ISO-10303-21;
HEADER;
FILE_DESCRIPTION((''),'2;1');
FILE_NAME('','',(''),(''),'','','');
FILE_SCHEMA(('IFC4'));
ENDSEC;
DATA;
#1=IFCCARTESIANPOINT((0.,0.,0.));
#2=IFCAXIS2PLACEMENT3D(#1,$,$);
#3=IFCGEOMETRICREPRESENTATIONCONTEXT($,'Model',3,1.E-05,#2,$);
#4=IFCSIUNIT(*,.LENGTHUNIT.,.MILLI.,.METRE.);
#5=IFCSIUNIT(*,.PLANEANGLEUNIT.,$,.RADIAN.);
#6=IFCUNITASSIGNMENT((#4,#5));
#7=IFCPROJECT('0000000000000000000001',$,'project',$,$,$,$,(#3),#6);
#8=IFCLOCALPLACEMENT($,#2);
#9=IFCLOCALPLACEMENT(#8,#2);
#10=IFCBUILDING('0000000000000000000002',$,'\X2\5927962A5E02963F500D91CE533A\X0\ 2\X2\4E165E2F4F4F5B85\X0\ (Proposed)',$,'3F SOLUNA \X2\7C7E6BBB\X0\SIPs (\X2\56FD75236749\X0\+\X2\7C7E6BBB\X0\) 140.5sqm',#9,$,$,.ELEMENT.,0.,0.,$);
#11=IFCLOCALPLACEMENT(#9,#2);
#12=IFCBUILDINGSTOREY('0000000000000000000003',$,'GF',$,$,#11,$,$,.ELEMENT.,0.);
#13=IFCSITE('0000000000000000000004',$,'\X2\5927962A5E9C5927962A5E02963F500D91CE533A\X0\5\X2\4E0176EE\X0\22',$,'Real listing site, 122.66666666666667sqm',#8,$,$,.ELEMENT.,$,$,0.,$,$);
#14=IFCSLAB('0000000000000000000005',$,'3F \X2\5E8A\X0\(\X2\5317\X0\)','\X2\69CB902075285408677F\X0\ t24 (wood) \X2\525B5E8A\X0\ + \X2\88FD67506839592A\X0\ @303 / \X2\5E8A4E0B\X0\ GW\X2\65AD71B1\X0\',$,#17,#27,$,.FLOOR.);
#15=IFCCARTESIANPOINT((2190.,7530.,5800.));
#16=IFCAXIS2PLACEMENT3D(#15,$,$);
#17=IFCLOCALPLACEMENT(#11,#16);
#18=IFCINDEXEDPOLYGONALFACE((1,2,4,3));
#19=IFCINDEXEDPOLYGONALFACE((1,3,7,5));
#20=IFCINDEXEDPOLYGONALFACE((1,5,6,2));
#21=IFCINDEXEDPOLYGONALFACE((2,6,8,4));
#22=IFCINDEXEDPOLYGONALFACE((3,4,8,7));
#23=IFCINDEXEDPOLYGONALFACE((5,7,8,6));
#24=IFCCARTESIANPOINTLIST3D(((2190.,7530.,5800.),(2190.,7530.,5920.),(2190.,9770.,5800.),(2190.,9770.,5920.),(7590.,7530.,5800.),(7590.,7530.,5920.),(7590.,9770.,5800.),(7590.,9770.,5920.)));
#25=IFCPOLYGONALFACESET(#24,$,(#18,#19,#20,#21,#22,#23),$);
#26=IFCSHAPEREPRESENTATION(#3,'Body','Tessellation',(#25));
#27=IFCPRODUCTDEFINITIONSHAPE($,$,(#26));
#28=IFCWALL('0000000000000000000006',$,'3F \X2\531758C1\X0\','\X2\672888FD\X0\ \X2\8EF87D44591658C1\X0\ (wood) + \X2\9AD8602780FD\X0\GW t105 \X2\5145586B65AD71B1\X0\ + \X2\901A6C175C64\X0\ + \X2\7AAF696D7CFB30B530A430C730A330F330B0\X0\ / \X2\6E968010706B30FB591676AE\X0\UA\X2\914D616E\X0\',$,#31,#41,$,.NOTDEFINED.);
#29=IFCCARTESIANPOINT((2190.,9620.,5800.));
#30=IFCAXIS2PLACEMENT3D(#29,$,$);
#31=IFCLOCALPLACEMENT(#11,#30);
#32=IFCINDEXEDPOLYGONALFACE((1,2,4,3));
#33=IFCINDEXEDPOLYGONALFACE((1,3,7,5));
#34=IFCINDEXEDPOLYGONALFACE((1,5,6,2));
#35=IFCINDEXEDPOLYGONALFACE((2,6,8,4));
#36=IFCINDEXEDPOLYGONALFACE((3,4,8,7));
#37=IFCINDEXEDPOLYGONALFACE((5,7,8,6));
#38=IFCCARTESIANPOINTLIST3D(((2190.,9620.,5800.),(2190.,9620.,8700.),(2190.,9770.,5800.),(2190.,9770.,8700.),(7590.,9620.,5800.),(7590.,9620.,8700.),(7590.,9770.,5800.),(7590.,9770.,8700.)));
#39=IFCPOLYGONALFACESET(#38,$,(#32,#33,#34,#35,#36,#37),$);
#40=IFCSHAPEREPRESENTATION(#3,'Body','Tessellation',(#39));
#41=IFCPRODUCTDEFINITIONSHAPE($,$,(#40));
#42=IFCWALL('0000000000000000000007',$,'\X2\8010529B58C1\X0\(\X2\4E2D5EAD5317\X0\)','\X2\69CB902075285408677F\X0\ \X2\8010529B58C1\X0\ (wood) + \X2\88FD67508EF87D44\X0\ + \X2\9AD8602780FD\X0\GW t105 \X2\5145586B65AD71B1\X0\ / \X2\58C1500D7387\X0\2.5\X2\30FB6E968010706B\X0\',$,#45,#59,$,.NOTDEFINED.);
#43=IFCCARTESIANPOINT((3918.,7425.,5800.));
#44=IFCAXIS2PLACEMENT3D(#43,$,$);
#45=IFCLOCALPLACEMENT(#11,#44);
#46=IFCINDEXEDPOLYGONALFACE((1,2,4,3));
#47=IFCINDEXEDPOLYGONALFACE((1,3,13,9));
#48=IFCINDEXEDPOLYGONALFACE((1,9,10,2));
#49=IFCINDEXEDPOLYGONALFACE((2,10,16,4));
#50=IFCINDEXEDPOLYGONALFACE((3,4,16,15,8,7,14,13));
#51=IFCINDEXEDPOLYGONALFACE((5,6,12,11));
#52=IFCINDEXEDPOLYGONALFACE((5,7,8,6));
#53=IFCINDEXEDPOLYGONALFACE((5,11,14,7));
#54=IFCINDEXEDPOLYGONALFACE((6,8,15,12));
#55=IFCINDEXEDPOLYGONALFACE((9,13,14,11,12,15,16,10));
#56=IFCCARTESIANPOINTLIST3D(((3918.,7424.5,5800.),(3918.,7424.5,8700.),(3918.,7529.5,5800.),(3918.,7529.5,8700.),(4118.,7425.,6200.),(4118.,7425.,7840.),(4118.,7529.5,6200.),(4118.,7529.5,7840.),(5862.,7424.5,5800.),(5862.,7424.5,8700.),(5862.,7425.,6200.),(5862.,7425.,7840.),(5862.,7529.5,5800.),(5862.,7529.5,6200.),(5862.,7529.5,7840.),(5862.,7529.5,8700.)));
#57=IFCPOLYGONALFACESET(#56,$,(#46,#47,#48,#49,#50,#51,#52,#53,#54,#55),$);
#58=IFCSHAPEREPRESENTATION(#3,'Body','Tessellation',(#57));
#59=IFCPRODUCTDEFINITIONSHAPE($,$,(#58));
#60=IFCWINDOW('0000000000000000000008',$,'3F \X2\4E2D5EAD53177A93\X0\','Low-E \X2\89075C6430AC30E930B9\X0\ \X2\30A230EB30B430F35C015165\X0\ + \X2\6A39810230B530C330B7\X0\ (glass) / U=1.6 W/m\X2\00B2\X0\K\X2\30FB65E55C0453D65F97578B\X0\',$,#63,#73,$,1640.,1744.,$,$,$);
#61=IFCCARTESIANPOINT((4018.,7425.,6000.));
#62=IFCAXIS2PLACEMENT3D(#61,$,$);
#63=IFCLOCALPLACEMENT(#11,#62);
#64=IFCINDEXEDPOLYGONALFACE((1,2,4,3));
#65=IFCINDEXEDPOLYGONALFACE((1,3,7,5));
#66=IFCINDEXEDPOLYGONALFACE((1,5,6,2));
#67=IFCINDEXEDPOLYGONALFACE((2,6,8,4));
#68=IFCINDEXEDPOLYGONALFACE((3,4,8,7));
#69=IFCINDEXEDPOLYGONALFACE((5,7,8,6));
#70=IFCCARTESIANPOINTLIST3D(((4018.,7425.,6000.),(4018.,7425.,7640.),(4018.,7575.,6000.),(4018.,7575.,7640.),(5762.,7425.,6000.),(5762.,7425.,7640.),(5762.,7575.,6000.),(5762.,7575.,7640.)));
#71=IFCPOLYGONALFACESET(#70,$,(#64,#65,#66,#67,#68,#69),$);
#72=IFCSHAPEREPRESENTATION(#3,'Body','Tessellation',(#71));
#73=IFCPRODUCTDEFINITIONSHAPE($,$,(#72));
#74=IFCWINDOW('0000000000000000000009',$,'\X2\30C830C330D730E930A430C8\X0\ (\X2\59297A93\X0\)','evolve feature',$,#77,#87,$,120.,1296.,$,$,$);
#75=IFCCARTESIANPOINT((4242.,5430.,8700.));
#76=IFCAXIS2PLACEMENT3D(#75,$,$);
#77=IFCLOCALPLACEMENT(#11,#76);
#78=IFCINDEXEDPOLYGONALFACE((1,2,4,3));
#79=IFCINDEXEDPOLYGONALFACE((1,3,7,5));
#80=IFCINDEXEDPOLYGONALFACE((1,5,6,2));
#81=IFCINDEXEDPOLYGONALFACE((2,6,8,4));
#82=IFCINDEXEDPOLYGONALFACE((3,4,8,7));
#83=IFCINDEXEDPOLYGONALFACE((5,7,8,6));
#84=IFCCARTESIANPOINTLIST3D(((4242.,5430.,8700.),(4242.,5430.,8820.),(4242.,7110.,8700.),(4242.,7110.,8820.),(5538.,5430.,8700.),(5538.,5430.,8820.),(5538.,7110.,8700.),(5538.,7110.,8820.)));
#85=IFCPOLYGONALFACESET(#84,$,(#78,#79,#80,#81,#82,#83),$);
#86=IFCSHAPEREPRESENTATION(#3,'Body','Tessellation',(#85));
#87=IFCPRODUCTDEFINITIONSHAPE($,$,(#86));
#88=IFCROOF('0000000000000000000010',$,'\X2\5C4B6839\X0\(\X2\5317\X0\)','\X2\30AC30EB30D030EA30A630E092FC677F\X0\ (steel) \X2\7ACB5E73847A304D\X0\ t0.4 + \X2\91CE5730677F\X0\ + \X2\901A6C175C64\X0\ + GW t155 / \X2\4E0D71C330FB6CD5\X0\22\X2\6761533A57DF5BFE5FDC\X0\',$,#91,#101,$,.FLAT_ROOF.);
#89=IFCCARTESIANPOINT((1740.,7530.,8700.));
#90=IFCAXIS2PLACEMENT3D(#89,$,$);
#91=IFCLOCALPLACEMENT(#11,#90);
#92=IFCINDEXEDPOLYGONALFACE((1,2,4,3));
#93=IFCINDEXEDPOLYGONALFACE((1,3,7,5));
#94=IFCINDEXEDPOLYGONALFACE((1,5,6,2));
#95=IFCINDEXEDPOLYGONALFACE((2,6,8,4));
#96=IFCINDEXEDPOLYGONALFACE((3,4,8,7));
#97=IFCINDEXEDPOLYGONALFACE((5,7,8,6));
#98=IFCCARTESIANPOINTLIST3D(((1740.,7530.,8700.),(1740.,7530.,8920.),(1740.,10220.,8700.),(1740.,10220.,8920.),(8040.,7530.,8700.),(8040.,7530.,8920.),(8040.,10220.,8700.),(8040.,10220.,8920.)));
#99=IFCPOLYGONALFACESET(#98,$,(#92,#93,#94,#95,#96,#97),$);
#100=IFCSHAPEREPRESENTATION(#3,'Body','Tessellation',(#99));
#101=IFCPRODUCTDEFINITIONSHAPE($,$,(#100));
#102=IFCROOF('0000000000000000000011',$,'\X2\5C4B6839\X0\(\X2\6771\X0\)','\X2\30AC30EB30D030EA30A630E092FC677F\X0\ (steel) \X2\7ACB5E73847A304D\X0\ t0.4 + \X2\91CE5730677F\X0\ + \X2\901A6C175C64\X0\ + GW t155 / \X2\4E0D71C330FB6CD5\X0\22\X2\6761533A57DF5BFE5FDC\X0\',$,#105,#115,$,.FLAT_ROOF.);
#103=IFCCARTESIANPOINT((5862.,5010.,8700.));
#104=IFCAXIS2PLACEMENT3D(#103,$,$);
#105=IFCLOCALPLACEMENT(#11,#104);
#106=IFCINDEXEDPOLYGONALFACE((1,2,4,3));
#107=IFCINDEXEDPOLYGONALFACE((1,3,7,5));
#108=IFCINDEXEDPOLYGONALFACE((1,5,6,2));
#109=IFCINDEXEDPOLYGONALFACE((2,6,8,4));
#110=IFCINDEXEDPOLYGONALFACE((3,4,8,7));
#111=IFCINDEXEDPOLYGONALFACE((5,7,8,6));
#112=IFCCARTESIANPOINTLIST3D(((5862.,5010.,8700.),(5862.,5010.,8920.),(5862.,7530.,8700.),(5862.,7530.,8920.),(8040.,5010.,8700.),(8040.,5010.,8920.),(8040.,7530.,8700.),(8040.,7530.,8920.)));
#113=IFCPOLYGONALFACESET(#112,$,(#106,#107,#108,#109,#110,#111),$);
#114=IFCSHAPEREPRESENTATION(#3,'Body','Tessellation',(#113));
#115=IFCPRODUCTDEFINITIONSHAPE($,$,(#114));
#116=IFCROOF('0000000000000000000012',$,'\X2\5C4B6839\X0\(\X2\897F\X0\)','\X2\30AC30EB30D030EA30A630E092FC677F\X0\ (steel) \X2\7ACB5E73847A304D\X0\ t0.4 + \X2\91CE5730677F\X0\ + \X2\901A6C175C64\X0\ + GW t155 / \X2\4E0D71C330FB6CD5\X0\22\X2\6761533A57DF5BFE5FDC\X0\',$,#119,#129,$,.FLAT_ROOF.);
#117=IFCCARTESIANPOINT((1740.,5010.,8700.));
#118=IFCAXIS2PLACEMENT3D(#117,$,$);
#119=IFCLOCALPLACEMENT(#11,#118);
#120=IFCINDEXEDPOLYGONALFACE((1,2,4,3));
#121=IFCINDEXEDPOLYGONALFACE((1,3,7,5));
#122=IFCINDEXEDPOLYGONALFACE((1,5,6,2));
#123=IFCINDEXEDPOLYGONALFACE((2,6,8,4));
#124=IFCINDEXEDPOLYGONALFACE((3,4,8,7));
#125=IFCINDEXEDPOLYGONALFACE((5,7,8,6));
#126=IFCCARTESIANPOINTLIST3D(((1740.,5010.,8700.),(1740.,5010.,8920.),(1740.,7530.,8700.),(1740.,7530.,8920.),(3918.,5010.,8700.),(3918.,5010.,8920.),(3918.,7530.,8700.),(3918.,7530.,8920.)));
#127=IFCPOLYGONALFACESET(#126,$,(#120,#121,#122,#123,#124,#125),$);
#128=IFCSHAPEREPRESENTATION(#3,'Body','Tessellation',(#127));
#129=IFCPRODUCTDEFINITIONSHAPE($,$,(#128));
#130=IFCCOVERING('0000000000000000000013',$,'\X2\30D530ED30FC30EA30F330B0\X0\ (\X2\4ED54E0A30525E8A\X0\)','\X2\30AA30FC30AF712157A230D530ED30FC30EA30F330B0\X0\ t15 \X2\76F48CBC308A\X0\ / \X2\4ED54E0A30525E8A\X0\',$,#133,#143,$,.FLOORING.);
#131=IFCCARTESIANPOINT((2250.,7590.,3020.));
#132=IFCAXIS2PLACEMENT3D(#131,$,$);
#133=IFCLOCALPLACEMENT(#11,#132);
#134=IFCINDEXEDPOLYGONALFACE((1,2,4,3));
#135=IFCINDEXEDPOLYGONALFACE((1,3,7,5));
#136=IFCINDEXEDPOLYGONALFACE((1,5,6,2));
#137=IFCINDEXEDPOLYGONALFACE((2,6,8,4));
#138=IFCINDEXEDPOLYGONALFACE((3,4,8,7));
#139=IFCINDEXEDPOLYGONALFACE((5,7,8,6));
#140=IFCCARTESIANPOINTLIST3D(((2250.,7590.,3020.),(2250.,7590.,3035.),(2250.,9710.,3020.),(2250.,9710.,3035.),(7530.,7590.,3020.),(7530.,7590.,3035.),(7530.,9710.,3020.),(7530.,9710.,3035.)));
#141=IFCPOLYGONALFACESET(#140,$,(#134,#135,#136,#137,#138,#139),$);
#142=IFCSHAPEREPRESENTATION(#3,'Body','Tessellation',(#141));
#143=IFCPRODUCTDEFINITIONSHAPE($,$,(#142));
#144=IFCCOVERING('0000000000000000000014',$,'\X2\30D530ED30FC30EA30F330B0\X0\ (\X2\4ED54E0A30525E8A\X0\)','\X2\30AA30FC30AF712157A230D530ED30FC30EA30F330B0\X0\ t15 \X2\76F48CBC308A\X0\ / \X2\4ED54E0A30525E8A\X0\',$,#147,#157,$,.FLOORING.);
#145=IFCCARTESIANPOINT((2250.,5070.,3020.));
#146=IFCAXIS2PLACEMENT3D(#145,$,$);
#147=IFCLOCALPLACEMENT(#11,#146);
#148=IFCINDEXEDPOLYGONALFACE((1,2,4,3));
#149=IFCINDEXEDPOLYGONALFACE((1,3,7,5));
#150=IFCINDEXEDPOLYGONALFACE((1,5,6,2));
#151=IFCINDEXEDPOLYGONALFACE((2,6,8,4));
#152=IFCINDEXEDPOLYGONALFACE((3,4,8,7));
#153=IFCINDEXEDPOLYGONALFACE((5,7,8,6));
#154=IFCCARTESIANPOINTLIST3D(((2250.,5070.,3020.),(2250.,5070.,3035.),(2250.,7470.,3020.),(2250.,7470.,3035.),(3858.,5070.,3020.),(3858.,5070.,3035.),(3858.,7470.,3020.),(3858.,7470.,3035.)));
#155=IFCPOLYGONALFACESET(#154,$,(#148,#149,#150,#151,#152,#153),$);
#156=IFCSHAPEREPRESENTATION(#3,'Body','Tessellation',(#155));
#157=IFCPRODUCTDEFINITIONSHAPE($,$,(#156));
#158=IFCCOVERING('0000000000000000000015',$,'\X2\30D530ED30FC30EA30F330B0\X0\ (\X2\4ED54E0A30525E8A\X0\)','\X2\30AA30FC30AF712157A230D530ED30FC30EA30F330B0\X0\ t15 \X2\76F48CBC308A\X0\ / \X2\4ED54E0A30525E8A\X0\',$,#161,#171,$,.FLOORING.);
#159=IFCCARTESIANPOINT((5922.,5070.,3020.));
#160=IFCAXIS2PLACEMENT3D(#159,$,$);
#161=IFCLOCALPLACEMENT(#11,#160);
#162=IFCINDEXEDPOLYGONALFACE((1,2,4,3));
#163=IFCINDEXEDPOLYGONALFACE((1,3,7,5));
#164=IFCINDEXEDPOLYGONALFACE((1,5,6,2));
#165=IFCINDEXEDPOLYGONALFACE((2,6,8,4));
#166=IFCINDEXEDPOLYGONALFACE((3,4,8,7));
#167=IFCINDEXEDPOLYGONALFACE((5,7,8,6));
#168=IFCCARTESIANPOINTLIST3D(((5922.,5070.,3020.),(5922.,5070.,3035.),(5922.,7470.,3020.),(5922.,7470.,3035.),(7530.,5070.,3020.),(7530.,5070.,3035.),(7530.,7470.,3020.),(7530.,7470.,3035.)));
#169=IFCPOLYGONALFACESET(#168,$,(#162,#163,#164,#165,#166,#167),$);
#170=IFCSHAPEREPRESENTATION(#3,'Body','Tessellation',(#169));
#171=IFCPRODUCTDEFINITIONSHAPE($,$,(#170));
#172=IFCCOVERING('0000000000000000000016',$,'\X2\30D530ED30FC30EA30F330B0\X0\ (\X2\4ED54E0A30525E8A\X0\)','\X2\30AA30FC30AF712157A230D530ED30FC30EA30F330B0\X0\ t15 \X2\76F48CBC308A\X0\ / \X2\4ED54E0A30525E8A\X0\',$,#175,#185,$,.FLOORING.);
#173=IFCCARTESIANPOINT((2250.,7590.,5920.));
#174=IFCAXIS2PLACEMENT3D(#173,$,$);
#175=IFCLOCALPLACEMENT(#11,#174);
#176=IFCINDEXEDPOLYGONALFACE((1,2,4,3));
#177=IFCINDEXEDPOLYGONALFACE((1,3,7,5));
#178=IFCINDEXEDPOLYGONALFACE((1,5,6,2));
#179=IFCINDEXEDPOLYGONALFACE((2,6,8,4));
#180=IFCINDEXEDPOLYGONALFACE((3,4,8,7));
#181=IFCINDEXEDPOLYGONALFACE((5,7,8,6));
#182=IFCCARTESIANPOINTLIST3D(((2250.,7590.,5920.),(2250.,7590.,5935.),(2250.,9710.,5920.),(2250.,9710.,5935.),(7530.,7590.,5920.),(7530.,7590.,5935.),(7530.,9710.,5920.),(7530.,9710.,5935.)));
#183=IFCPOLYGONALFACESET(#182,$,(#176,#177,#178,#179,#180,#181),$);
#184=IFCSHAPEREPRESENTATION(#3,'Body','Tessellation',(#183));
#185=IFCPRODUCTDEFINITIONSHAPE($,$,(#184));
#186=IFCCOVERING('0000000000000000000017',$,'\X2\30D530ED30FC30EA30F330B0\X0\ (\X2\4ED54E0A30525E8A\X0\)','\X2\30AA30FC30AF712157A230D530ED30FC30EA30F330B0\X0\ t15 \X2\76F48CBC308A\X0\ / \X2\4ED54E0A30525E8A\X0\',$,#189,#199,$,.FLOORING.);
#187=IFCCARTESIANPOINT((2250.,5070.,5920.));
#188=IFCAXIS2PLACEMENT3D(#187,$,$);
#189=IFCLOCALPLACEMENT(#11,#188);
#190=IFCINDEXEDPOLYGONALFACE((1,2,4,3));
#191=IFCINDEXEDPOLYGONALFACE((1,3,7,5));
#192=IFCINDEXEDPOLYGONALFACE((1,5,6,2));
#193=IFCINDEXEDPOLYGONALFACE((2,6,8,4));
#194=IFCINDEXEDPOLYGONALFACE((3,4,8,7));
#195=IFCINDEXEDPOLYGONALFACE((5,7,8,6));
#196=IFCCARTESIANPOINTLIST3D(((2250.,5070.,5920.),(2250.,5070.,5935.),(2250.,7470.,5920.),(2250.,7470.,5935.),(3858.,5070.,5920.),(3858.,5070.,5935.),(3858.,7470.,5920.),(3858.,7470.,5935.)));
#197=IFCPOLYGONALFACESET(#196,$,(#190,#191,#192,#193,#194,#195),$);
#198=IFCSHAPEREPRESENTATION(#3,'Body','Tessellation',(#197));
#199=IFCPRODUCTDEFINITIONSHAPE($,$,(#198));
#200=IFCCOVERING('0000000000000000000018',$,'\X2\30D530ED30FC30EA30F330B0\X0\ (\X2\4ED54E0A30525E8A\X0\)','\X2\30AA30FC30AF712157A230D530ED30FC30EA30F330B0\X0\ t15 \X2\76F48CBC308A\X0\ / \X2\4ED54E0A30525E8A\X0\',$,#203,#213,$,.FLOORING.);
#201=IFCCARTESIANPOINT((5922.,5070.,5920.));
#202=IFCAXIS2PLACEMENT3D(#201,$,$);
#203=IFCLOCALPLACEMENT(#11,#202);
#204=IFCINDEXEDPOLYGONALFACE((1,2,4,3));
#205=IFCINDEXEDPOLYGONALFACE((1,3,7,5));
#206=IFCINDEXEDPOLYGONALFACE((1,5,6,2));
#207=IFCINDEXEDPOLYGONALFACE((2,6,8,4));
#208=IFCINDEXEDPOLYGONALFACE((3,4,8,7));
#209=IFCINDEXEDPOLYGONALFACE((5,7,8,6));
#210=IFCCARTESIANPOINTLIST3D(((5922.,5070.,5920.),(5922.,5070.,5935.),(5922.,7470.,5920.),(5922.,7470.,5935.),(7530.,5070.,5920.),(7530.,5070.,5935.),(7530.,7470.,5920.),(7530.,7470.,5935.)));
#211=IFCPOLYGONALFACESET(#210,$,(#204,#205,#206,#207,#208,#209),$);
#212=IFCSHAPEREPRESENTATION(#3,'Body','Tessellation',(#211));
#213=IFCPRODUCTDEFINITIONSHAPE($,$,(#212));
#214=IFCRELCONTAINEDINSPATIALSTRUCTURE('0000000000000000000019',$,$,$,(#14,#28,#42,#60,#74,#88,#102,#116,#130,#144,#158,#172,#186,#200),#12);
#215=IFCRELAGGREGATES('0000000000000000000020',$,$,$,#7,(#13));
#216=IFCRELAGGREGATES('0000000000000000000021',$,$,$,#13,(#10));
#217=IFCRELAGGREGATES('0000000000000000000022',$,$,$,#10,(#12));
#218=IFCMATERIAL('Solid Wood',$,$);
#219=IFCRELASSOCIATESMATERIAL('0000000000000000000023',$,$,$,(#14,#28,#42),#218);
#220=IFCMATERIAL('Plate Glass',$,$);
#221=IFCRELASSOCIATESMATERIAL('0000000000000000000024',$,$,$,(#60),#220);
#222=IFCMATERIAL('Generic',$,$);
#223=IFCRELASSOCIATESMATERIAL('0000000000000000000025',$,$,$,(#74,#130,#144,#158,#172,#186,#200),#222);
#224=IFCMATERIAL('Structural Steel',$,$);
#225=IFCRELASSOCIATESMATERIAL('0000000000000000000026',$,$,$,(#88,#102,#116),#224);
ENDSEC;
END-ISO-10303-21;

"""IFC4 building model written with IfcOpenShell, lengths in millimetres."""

from ifc_helpers import new_model, si_unit, frame, frame_2d, origin, place, context, project, spatial, rectangle, extrude, material, element, fill, save


model = new_model("IFC4")

# Units and contexts
model_context = context("Model", 3, precision=1e-05, world=origin())
ifc_project = project(units=[si_unit("LENGTHUNIT", "METRE", prefix="MILLI"), si_unit("PLANEANGLEUNIT", "RADIAN")], contexts=[model_context])

# Site, building, storey
site_placement = place(None, origin())
site = spatial("IfcSite", under=ifc_project, at=site_placement, Name="大阪府大阪市阿倍野区5丁目22", ObjectType="Real listing site, 122.66666666666667sqm", CompositionType="ELEMENT", RefElevation=0.0)
building_placement = place(site_placement, origin())
building = spatial("IfcBuilding", under=site, at=building_placement, Name="大阪市阿倍野区 2世帯住宅 (Proposed)", ObjectType="3F SOLUNA 籾殻SIPs (国産杉+籾殻) 140.5sqm", CompositionType="ELEMENT", ElevationOfRefHeight=0.0, ElevationOfTerrain=0.0)
storey_placement = place(building_placement, origin())
storey = spatial("IfcBuildingStorey", under=building, at=storey_placement, Name="GF", CompositionType="ELEMENT", Elevation=0.0)

# Slab
ifc_material_1 = material(Name="Solid Wood")
slab_placement = place(storey_placement, frame((2190.0, 7530.0, 5800.0)))
element("IfcSlab", 1, at=slab_placement, inside=storey, material=ifc_material_1, Name="3F 床(北)", Description="構造用合板 t24 (wood) 剛床 + 製材根太 @303 / 床下 GW断熱", PredefinedType="FLOOR", context=model_context, shape_type="SweptSolid", body=[
    extrude(rectangle(XDim=5400.0, YDim=2240.0, at=frame_2d((2700.0, 1120.0))), frame((2190.0, 7530.0, 5800.0)), (0.0, 0.0, 1.0), 120.0),
])

# Wall
wall_1_placement = place(storey_placement, frame((2190.0, 9620.0, 5800.0)))
element("IfcWall", 2, at=wall_1_placement, inside=storey, material=ifc_material_1, Name="3F 北壁", Description="木製 軸組外壁 (wood) + 高性能GW t105 充填断熱 + 通気層 + 窯業系サイディング / 準耐火・外皮UA配慮", PredefinedType="NOTDEFINED", context=model_context, shape_type="SweptSolid", body=[
    extrude(rectangle(XDim=5400.0, YDim=150.0, at=frame_2d((2700.0, 75.0))), frame((2190.0, 9620.0, 5800.0)), (0.0, 0.0, 1.0), 2900.0),
])

# Wall, opening, window
wall_2_placement = place(storey_placement, frame((3918.0, 7425.0, 5800.0)))
wall_2 = element("IfcWall", 3, at=wall_2_placement, inside=storey, material=ifc_material_1, Name="耐力壁(中庭北)", Description="構造用合板 耐力壁 (wood) + 製材軸組 + 高性能GW t105 充填断熱 / 壁倍率2.5・準耐火", PredefinedType="NOTDEFINED", context=model_context, shape_type="SweptSolid", body=[
    extrude(rectangle(XDim=1944.0, YDim=105.0, at=frame_2d((972.0, 52.0))), frame((3918.0, 7425.0, 5800.0)), (0.0, 0.0, 1.0), 2900.0),
])
opening_placement = place(storey_placement, frame((4018.0, 7425.0, 6000.0)))
opening = element("IfcOpeningElement", 4, at=opening_placement, cuts=wall_2, PredefinedType="NOTDEFINED", context=model_context, shape_type="SweptSolid", body=[
    extrude(rectangle(XDim=1744.0, YDim=150.0, at=frame_2d((872.0, 75.0))), frame((4018.0, 7425.0, 6000.0)), (0.0, 0.0, 1.0), 1640.0),
])
ifc_material_2 = material(Name="Plate Glass")
window_1_placement = place(storey_placement, frame((4018.0, 7425.0, 6000.0)))
window_1 = element("IfcWindow", 5, at=window_1_placement, inside=storey, material=ifc_material_2, Name="3F 中庭北窓", Description="Low-E 複層ガラス アルゴン封入 + 樹脂サッシ (glass) / U=1.6 W/m²K・日射取得型", OverallHeight=1640.0, OverallWidth=1744.0, context=model_context, shape_type="SweptSolid", body=[
    extrude(rectangle(XDim=1744.0, YDim=150.0, at=frame_2d((872.0, 75.0))), frame((4018.0, 7425.0, 6000.0)), (0.0, 0.0, 1.0), 1640.0),
])
fill(opening, window_1)

# Window
ifc_material_3 = material(Name="Generic")
window_2_placement = place(storey_placement, frame((4242.0, 5430.0, 8700.0)))
element("IfcWindow", 6, at=window_2_placement, inside=storey, material=ifc_material_3, Name="トップライト (天窓)", Description="evolve feature", OverallHeight=120.0, OverallWidth=1296.0, context=model_context, shape_type="SweptSolid", body=[
    extrude(rectangle(XDim=1296.0, YDim=1680.0, at=frame_2d((648.0, 840.0))), frame((4242.0, 5430.0, 8700.0)), (0.0, 0.0, 1.0), 120.0),
])

# Roofs
ifc_material_4 = material(Name="Structural Steel")
roof_1_placement = place(storey_placement, frame((1740.0, 7530.0, 8700.0)))
element("IfcRoof", 7, at=roof_1_placement, inside=storey, material=ifc_material_4, Name="屋根(北)", Description="ガルバリウム鋼板 (steel) 立平葺き t0.4 + 野地板 + 通気層 + GW t155 / 不燃・法22条区域対応", PredefinedType="FLAT_ROOF", context=model_context, shape_type="SweptSolid", body=[
    extrude(rectangle(XDim=6300.0, YDim=2690.0, at=frame_2d((3150.0, 1345.0))), frame((1740.0, 7530.0, 8700.0)), (0.0, 0.0, 1.0), 220.0),
])
roof_2_placement = place(storey_placement, frame((5862.0, 5010.0, 8700.0)))
element("IfcRoof", 8, at=roof_2_placement, inside=storey, material=ifc_material_4, Name="屋根(東)", Description="ガルバリウム鋼板 (steel) 立平葺き t0.4 + 野地板 + 通気層 + GW t155 / 不燃・法22条区域対応", PredefinedType="FLAT_ROOF", context=model_context, shape_type="SweptSolid", body=[
    extrude(rectangle(XDim=2178.0, YDim=2520.0, at=frame_2d((1089.0, 1260.0))), frame((5862.0, 5010.0, 8700.0)), (0.0, 0.0, 1.0), 220.0),
])
roof_3_placement = place(storey_placement, frame((1740.0, 5010.0, 8700.0)))
element("IfcRoof", 9, at=roof_3_placement, inside=storey, material=ifc_material_4, Name="屋根(西)", Description="ガルバリウム鋼板 (steel) 立平葺き t0.4 + 野地板 + 通気層 + GW t155 / 不燃・法22条区域対応", PredefinedType="FLAT_ROOF", context=model_context, shape_type="SweptSolid", body=[
    extrude(rectangle(XDim=2178.0, YDim=2520.0, at=frame_2d((1089.0, 1260.0))), frame((1740.0, 5010.0, 8700.0)), (0.0, 0.0, 1.0), 220.0),
])

# Coverings
covering_1_placement = place(storey_placement, frame((2250.0, 7590.0, 3020.0)))
element("IfcCovering", 10, at=covering_1_placement, inside=storey, material=ifc_material_3, Name="フローリング (仕上げ床)", Description="オーク無垢フローリング t15 直貼り / 仕上げ床", PredefinedType="FLOORING", context=model_context, shape_type="SweptSolid", body=[
    extrude(rectangle(XDim=5280.0, YDim=2120.0, at=frame_2d((2640.0, 1060.0))), frame((2250.0, 7590.0, 3020.0)), (0.0, 0.0, 1.0), 15.0),
])
covering_2_placement = place(storey_placement, frame((2250.0, 5070.0, 3020.0)))
element("IfcCovering", 11, at=covering_2_placement, inside=storey, material=ifc_material_3, Name="フローリング (仕上げ床)", Description="オーク無垢フローリング t15 直貼り / 仕上げ床", PredefinedType="FLOORING", context=model_context, shape_type="SweptSolid", body=[
    extrude(rectangle(XDim=1608.0, YDim=2400.0, at=frame_2d((804.0, 1200.0))), frame((2250.0, 5070.0, 3020.0)), (0.0, 0.0, 1.0), 15.0),
])
covering_3_placement = place(storey_placement, frame((5922.0, 5070.0, 3020.0)))
element("IfcCovering", 12, at=covering_3_placement, inside=storey, material=ifc_material_3, Name="フローリング (仕上げ床)", Description="オーク無垢フローリング t15 直貼り / 仕上げ床", PredefinedType="FLOORING", context=model_context, shape_type="SweptSolid", body=[
    extrude(rectangle(XDim=1608.0, YDim=2400.0, at=frame_2d((804.0, 1200.0))), frame((5922.0, 5070.0, 3020.0)), (0.0, 0.0, 1.0), 15.0),
])
covering_4_placement = place(storey_placement, frame((2250.0, 7590.0, 5920.0)))
element("IfcCovering", 13, at=covering_4_placement, inside=storey, material=ifc_material_3, Name="フローリング (仕上げ床)", Description="オーク無垢フローリング t15 直貼り / 仕上げ床", PredefinedType="FLOORING", context=model_context, shape_type="SweptSolid", body=[
    extrude(rectangle(XDim=5280.0, YDim=2120.0, at=frame_2d((2640.0, 1060.0))), frame((2250.0, 7590.0, 5920.0)), (0.0, 0.0, 1.0), 15.0),
])
covering_5_placement = place(storey_placement, frame((2250.0, 5070.0, 5920.0)))
element("IfcCovering", 14, at=covering_5_placement, inside=storey, material=ifc_material_3, Name="フローリング (仕上げ床)", Description="オーク無垢フローリング t15 直貼り / 仕上げ床", PredefinedType="FLOORING", context=model_context, shape_type="SweptSolid", body=[
    extrude(rectangle(XDim=1608.0, YDim=2400.0, at=frame_2d((804.0, 1200.0))), frame((2250.0, 5070.0, 5920.0)), (0.0, 0.0, 1.0), 15.0),
])
covering_6_placement = place(storey_placement, frame((5922.0, 5070.0, 5920.0)))
element("IfcCovering", 15, at=covering_6_placement, inside=storey, material=ifc_material_3, Name="フローリング (仕上げ床)", Description="オーク無垢フローリング t15 直貼り / 仕上げ床", PredefinedType="FLOORING", context=model_context, shape_type="SweptSolid", body=[
    extrude(rectangle(XDim=1608.0, YDim=2400.0, at=frame_2d((804.0, 1200.0))), frame((5922.0, 5070.0, 5920.0)), (0.0, 0.0, 1.0), 15.0),
])

save(model, "model.ifc")
